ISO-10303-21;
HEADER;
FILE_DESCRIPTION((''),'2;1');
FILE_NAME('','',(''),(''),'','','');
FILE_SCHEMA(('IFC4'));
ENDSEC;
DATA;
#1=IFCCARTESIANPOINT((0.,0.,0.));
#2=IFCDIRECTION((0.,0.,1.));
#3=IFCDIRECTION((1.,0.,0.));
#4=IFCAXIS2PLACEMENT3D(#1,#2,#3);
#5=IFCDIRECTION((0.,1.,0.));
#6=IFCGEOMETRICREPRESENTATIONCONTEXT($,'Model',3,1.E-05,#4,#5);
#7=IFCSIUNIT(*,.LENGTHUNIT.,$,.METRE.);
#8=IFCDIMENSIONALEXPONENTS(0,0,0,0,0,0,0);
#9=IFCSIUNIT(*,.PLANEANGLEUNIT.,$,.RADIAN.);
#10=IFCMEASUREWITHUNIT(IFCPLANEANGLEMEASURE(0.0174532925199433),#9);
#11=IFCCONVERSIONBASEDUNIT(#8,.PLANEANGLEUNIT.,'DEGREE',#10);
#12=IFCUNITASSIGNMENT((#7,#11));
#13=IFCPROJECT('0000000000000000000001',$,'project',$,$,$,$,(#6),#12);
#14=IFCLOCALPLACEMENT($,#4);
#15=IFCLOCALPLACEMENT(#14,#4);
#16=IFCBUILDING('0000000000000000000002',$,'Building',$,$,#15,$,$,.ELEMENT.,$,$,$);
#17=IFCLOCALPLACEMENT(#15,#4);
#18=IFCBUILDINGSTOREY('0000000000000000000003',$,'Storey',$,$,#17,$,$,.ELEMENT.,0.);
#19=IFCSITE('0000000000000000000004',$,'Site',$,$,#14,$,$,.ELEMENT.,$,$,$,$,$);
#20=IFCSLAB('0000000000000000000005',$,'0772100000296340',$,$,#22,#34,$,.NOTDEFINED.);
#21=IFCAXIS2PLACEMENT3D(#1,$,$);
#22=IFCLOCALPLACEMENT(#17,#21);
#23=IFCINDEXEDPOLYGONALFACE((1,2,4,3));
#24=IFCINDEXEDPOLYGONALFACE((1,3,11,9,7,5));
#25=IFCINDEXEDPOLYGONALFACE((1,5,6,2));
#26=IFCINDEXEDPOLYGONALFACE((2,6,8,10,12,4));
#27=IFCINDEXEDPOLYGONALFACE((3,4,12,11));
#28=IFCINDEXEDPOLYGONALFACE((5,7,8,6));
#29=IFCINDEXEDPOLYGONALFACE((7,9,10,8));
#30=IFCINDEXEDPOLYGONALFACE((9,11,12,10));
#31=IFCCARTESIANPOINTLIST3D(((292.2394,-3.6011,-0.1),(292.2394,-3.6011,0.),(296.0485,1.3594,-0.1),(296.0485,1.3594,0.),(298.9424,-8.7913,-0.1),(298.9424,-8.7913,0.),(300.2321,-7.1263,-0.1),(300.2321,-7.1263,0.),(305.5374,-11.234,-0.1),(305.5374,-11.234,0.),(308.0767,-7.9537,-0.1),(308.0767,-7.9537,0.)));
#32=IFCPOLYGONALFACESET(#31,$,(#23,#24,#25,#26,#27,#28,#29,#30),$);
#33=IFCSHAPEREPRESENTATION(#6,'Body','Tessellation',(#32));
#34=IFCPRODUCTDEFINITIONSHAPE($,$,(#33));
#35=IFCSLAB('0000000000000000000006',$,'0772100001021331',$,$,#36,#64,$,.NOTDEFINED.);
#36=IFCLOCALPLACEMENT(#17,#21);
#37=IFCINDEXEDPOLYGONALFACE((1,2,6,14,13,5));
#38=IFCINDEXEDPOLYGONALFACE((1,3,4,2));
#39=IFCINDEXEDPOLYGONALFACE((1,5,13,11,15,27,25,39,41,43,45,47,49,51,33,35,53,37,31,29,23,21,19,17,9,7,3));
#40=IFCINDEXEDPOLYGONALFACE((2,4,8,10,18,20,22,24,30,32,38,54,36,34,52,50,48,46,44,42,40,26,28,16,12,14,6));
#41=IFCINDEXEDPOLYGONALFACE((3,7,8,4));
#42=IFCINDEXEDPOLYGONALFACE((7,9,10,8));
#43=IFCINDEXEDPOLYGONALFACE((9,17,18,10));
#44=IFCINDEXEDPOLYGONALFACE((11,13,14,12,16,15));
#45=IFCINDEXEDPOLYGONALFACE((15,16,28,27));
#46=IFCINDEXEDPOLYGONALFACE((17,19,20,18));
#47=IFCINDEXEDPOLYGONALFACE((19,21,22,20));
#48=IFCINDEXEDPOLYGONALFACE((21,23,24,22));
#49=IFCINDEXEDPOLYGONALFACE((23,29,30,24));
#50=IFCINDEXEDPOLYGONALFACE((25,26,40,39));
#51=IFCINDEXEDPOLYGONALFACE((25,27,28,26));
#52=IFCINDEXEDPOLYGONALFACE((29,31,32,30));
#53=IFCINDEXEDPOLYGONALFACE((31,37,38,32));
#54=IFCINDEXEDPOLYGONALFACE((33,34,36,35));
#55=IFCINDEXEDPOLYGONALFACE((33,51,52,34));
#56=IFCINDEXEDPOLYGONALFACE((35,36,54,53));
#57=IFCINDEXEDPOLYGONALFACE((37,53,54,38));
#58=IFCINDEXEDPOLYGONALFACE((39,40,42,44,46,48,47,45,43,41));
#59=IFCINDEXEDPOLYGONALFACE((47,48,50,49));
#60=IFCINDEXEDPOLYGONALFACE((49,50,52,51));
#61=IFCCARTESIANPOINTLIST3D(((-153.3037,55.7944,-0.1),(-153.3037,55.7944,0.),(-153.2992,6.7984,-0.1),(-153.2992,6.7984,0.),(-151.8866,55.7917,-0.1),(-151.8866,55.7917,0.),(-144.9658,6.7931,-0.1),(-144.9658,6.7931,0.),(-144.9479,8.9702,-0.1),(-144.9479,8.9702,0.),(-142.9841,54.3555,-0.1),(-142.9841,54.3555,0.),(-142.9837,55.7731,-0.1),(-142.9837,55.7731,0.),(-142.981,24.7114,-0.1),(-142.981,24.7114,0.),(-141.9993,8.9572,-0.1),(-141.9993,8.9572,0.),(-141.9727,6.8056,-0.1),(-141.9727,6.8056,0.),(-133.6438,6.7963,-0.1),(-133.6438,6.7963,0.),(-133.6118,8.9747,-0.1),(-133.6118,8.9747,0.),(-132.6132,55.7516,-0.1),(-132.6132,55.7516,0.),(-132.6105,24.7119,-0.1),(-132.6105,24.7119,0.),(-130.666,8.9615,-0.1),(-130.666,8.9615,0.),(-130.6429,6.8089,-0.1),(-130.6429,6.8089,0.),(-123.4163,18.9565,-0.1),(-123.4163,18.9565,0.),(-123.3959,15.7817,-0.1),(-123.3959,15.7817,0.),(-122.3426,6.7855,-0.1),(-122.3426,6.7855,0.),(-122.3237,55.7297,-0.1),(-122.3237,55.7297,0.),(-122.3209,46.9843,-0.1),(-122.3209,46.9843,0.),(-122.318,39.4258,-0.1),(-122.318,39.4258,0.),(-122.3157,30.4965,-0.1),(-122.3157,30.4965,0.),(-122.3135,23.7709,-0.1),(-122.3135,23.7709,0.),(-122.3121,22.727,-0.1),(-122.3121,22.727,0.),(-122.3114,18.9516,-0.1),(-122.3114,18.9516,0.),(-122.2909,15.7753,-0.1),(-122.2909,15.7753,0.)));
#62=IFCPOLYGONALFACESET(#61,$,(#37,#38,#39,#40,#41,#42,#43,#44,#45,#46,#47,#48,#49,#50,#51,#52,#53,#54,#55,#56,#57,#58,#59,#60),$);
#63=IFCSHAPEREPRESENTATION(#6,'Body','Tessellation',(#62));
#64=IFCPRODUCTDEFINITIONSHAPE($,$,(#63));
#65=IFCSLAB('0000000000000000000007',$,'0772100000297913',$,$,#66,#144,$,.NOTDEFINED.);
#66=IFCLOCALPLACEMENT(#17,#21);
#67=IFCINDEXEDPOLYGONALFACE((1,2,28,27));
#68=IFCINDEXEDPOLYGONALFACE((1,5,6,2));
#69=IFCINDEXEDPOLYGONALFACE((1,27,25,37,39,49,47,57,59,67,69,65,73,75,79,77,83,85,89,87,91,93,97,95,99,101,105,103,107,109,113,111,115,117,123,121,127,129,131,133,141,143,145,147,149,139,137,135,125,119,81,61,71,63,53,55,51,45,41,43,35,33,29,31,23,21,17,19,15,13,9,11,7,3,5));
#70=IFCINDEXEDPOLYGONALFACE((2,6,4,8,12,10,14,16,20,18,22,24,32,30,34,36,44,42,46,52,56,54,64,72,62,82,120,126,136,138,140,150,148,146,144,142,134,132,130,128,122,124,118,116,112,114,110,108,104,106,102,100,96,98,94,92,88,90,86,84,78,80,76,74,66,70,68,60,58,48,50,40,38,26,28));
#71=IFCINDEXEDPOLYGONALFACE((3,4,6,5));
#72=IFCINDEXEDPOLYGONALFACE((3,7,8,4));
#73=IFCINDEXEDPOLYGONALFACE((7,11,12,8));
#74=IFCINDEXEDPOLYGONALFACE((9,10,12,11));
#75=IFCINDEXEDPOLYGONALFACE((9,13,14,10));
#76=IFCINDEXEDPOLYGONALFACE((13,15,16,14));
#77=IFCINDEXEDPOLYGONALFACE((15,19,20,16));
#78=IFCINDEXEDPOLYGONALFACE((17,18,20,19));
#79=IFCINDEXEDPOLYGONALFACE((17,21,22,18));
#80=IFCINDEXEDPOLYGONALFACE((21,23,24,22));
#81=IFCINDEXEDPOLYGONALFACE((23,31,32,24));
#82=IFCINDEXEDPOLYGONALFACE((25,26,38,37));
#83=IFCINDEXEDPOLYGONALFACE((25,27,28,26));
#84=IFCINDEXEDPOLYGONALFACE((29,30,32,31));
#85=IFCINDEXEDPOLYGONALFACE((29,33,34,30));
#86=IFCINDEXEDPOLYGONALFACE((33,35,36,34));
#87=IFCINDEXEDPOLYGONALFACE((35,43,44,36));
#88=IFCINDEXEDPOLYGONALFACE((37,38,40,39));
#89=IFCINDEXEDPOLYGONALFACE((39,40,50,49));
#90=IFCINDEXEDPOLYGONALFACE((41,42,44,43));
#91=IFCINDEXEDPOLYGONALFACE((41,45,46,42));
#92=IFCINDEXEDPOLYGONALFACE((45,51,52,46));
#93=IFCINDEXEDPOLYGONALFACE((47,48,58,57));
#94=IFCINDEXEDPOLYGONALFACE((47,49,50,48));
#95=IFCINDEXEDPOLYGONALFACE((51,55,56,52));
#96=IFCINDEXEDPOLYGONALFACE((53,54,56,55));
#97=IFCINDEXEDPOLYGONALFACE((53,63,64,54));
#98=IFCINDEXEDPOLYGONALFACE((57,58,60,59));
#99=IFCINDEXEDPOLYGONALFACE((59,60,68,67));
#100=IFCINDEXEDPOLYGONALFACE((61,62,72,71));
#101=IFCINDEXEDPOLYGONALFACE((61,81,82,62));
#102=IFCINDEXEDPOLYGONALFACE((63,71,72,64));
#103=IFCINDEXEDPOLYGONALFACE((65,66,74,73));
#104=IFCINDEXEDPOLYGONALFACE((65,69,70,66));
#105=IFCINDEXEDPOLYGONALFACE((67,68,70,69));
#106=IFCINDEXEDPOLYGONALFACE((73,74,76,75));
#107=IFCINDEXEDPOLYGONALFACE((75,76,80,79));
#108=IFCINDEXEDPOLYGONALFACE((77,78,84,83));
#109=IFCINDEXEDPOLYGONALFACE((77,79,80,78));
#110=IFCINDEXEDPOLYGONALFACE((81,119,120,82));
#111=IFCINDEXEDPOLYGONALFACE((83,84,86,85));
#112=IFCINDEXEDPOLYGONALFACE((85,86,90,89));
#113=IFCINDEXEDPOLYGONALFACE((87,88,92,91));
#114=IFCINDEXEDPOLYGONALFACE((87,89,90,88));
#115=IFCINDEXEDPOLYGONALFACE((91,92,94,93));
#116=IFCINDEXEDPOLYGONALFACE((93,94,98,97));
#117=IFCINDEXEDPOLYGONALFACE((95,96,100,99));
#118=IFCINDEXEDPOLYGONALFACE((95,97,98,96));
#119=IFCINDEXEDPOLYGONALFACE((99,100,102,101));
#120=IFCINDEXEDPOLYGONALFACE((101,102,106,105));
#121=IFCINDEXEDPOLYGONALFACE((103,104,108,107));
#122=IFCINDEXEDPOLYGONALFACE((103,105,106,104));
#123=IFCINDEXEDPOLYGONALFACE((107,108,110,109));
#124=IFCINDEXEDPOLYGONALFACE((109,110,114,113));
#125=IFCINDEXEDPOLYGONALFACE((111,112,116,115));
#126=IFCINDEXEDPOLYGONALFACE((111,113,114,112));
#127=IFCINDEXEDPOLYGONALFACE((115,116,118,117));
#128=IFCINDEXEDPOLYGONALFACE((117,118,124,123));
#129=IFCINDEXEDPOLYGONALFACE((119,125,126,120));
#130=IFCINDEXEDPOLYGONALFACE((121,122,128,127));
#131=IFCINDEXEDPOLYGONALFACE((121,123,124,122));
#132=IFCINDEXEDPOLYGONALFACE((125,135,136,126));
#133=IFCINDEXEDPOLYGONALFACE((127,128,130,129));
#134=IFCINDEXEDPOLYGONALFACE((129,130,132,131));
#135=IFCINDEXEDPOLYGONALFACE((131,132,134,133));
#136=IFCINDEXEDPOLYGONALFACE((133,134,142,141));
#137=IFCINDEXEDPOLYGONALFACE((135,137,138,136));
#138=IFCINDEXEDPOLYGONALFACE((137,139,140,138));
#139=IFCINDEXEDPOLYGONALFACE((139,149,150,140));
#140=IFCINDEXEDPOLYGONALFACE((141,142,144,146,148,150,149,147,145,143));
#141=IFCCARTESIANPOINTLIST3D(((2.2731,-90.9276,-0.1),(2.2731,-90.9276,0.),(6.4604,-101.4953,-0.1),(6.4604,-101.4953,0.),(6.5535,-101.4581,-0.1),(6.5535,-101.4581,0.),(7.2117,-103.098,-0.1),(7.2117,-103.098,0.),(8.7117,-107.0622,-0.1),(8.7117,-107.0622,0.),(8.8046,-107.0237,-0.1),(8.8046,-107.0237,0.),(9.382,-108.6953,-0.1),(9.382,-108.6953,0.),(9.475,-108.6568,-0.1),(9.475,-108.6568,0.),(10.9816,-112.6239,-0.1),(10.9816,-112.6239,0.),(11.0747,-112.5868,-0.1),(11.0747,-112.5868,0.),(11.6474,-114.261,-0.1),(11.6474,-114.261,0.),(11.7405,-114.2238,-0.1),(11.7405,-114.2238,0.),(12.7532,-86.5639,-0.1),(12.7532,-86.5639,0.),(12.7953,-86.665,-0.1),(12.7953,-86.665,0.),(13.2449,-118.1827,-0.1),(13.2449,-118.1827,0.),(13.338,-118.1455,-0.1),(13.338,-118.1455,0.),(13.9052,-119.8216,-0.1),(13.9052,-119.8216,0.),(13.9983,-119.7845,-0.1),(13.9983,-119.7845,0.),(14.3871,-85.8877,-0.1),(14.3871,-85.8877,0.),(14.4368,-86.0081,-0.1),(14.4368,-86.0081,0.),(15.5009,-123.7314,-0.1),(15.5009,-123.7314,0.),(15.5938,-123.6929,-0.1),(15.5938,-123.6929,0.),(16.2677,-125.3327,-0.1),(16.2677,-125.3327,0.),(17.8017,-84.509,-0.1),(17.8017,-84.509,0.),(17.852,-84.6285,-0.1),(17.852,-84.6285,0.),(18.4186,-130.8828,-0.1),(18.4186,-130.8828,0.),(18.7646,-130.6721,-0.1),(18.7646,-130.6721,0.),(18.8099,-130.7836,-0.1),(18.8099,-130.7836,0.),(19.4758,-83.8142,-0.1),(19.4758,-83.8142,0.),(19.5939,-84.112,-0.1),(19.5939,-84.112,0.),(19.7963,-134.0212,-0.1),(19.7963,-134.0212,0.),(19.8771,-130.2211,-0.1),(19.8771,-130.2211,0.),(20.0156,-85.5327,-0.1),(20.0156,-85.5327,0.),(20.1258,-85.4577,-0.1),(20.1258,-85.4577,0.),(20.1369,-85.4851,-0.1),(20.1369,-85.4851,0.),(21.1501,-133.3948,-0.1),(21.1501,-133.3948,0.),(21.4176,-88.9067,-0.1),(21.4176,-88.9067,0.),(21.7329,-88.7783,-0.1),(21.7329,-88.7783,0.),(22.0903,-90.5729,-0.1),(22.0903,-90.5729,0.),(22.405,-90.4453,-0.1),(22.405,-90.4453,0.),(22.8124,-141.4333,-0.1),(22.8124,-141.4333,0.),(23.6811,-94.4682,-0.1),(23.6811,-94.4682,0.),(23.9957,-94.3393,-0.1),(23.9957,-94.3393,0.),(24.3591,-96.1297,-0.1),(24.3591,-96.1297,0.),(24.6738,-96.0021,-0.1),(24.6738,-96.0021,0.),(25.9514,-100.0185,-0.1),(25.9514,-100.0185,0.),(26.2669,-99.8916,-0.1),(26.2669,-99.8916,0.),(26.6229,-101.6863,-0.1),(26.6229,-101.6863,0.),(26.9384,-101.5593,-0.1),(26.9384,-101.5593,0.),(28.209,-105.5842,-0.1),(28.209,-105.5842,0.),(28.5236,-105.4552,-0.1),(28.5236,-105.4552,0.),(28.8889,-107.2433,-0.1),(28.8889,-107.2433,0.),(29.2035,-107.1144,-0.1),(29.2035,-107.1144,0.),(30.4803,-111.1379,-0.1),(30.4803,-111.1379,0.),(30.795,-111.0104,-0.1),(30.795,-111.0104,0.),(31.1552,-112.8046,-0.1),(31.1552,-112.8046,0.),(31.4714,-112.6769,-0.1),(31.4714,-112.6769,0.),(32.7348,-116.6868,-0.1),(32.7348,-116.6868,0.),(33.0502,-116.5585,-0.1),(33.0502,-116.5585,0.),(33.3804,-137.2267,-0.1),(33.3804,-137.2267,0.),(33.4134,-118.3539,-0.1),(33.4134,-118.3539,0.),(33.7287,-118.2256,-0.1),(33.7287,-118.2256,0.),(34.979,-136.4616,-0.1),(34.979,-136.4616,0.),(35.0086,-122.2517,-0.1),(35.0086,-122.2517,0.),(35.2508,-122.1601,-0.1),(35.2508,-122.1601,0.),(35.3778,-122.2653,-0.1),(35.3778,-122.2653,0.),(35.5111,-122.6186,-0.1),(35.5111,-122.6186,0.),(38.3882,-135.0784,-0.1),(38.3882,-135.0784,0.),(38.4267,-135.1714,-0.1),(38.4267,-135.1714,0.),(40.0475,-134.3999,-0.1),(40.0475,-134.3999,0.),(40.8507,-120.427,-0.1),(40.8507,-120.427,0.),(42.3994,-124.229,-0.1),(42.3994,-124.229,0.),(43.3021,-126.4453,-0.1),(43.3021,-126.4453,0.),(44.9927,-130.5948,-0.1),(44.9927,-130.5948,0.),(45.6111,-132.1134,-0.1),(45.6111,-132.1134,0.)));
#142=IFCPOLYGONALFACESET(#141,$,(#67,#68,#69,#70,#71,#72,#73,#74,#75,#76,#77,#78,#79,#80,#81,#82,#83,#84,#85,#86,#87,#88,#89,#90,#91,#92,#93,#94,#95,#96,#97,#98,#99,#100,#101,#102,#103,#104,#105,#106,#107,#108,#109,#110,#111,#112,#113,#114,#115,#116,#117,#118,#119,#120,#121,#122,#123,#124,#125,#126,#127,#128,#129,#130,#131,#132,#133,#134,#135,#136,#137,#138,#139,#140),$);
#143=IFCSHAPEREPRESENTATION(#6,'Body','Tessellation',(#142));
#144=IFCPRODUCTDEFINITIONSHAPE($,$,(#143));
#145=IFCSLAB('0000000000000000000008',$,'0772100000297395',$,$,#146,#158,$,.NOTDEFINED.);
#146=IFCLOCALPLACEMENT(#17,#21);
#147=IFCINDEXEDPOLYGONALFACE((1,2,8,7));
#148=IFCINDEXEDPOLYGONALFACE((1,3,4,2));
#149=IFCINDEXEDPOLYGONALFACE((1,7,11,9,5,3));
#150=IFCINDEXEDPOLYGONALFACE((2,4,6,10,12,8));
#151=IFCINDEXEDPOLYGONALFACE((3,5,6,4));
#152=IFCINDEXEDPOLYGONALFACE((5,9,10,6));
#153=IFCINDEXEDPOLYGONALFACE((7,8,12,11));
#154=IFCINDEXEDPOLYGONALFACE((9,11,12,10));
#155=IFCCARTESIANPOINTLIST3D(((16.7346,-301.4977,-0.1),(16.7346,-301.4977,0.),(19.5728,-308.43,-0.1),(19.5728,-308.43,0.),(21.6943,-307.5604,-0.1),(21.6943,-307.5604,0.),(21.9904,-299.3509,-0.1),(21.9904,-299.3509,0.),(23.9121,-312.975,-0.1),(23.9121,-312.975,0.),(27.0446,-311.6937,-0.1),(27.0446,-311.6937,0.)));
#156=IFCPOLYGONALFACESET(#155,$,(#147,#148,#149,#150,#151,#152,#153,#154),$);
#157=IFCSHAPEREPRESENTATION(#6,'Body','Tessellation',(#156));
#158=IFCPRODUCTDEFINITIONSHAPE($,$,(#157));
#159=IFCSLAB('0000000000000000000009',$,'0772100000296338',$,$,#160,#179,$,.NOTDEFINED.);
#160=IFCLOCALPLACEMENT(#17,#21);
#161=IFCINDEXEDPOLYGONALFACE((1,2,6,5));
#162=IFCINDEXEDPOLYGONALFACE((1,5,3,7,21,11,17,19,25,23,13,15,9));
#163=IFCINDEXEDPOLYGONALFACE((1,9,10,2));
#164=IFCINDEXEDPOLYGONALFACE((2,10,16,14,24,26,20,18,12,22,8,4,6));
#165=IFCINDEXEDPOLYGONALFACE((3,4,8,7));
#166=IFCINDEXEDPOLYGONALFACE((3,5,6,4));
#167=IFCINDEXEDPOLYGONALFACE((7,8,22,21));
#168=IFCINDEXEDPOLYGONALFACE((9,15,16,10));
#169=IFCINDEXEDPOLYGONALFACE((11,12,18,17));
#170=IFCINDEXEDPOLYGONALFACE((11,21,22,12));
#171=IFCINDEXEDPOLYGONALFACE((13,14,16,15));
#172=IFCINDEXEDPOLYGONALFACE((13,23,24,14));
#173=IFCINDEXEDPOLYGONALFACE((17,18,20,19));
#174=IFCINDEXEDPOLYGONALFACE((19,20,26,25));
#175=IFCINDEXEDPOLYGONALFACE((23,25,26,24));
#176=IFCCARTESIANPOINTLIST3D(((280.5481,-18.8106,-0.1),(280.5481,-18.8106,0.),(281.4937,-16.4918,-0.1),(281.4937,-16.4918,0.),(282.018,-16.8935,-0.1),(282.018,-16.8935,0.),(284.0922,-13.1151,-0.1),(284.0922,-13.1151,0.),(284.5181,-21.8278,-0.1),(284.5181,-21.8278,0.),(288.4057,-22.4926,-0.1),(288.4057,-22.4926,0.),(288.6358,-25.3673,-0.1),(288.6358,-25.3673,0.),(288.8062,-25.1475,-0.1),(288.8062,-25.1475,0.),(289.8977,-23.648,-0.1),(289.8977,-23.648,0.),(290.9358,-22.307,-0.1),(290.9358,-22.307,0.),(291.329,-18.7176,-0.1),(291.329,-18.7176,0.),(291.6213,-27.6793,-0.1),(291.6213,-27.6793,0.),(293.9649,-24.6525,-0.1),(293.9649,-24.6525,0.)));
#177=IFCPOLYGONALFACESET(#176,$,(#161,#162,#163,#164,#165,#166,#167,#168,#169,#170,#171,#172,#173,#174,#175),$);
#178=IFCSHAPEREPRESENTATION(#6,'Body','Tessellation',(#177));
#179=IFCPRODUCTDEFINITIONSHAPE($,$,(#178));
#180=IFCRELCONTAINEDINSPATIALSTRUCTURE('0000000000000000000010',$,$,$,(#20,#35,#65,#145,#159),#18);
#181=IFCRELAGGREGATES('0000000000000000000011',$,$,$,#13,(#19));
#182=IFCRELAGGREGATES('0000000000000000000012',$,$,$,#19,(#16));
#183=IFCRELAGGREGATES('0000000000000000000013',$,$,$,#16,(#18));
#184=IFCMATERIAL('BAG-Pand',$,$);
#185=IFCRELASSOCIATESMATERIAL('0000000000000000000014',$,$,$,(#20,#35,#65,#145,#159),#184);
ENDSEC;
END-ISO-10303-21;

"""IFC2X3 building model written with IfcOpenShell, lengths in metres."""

from ifc_helpers import new_model, entity, si_unit, converted_unit, direction, frame, origin_with_axes, place, context, project, spatial, polyline, outline, extrude, material, element, save


model = new_model("IFC2X3")

# Units and contexts
model_context = context("Model", 3, precision=1e-05, world=origin_with_axes(), true_north=direction((0.0, 1.0, 0.0)))
ifc_project = project(units=[si_unit("LENGTHUNIT", "METRE"), converted_unit("PLANEANGLEUNIT", "DEGREE", entity("IfcPlaneAngleMeasure", 0.0174532925199433), si_unit("PLANEANGLEUNIT", "RADIAN"), dimensions=[0, 0, 0, 0, 0, 0, 0])], contexts=[model_context])

# Site, building, storey
site_placement = place(None, origin_with_axes())
site = spatial("IfcSite", under=ifc_project, at=site_placement, Name="Site", CompositionType="ELEMENT")
building_placement = place(site_placement, origin_with_axes())
building = spatial("IfcBuilding", under=site, at=building_placement, Name="Building", CompositionType="ELEMENT")
storey_placement = place(building_placement, origin_with_axes())
storey = spatial("IfcBuildingStorey", under=building, at=storey_placement, Name="Storey", CompositionType="ELEMENT", Elevation=0.0)

# Slabs
ifc_material = material(Name="BAG-Pand")
slab_1_placement = place(storey_placement, frame((0.0, 0.0, -0.1), z_axis=(0.0, 0.0, 1.0), x_axis=(1.0, 0.0, 0.0)))
element("IfcSlab", 1, at=slab_1_placement, inside=storey, material=ifc_material, Name="0772100000296340", PredefinedType="NOTDEFINED", context=model_context, shape_type="SweptSolid", body=[
    extrude(outline(polyline([(296.0485, 1.3594), (308.0767, -7.9537), (305.5374, -11.234), (300.2321, -7.1263), (298.9424, -8.7913), (292.2394, -3.6011), (296.0485, 1.3594)])), origin_with_axes(), (0.0, 0.0, 1.0), 0.1),
])
slab_2_placement = place(storey_placement, frame((0.0, 0.0, -0.1), z_axis=(0.0, 0.0, 1.0), x_axis=(1.0, 0.0, 0.0)))
element("IfcSlab", 2, at=slab_2_placement, inside=storey, material=ifc_material, Name="0772100001021331", PredefinedType="NOTDEFINED", context=model_context, shape_type="SweptSolid", body=[
    extrude(outline(polyline([(-153.3037, 55.7944), (-151.8866, 55.7917), (-142.9837, 55.7731), (-142.9841, 54.3555), (-142.981, 24.7114), (-132.6105, 24.7119), (-132.6132, 55.7516), (-122.3237, 55.7297), (-122.3209, 46.9843), (-122.318, 39.4258), (-122.3157, 30.4965), (-122.3135, 23.7709), (-122.3121, 22.727), (-122.3114, 18.9516), (-123.4163, 18.9565), (-123.3959, 15.7817), (-122.2909, 15.7753), (-122.3426, 6.7855), (-130.6429, 6.8089), (-130.666, 8.9615), (-133.6118, 8.9747), (-133.6438, 6.7963), (-141.9727, 6.8056), (-141.9993, 8.9572), (-144.9479, 8.9702), (-144.9658, 6.7931), (-153.2992, 6.7984), (-153.3037, 55.7944)])), origin_with_axes(), (0.0, 0.0, 1.0), 0.1),
])
slab_3_placement = place(storey_placement, frame((0.0, 0.0, -0.1), z_axis=(0.0, 0.0, 1.0), x_axis=(1.0, 0.0, 0.0)))
element("IfcSlab", 3, at=slab_3_placement, inside=storey, material=ifc_material, Name="0772100000297913", PredefinedType="NOTDEFINED", context=model_context, shape_type="SweptSolid", body=[
    extrude(outline(polyline([(19.7963, -134.0212), (21.1501, -133.3948), (19.8771, -130.2211), (18.7646, -130.6721), (18.8099, -130.7836), (18.4186, -130.8828), (16.2677, -125.3327), (15.5009, -123.7314), (15.5938, -123.6929), (13.9983, -119.7845), (13.9052, -119.8216), (13.2449, -118.1827), (13.338, -118.1455), (11.7405, -114.2238), (11.6474, -114.261), (10.9816, -112.6239), (11.0747, -112.5868), (9.475, -108.6568), (9.382, -108.6953), (8.7117, -107.0622), (8.8046, -107.0237), (7.2117, -103.098), (6.4604, -101.4953), (6.5535, -101.4581), (2.2731, -90.9276), (12.7953, -86.665), (12.7532, -86.5639), (14.3871, -85.8877), (14.4368, -86.0081), (17.852, -84.6285), (17.8017, -84.509), (19.4758, -83.8142), (19.5939, -84.112), (20.1258, -85.4577), (20.1369, -85.4851), (20.0156, -85.5327), (21.4176, -88.9067), (21.7329, -88.7783), (22.405, -90.4453), (22.0903, -90.5729), (23.6811, -94.4682), (23.9957, -94.3393), (24.6738, -96.0021), (24.3591, -96.1297), (25.9514, -100.0185), (26.2669, -99.8916), (26.9384, -101.5593), (26.6229, -101.6863), (28.209, -105.5842), (28.5236, -105.4552), (29.2035, -107.1144), (28.8889, -107.2433), (30.4803, -111.1379), (30.795, -111.0104), (31.4714, -112.6769), (31.1552, -112.8046), (32.7348, -116.6868), (33.0502, -116.5585), (33.7287, -118.2256), (33.4134, -118.3539), (35.0086, -122.2517), (35.2508, -122.1601), (35.3778, -122.2653), (35.5111, -122.6186), (40.8507, -120.427), (42.3994, -124.229), (43.3021, -126.4453), (44.9927, -130.5948), (45.6111, -132.1134), (40.0475, -134.3999), (38.4267, -135.1714), (38.3882, -135.0784), (34.979, -136.4616), (33.3804, -137.2267), (22.8124, -141.4333), (19.7963, -134.0212)])), origin_with_axes(), (0.0, 0.0, 1.0), 0.1),
])
slab_4_placement = place(storey_placement, frame((0.0, 0.0, -0.1), z_axis=(0.0, 0.0, 1.0), x_axis=(1.0, 0.0, 0.0)))
element("IfcSlab", 4, at=slab_4_placement, inside=storey, material=ifc_material, Name="0772100000297395", PredefinedType="NOTDEFINED", context=model_context, shape_type="SweptSolid", body=[
    extrude(outline(polyline([(21.6943, -307.5604), (19.5728, -308.43), (16.7346, -301.4977), (21.9904, -299.3509), (27.0446, -311.6937), (23.9121, -312.975), (21.6943, -307.5604)])), origin_with_axes(), (0.0, 0.0, 1.0), 0.1),
])
slab_5_placement = place(storey_placement, frame((0.0, 0.0, -0.1), z_axis=(0.0, 0.0, 1.0), x_axis=(1.0, 0.0, 0.0)))
element("IfcSlab", 5, at=slab_5_placement, inside=storey, material=ifc_material, Name="0772100000296338", PredefinedType="NOTDEFINED", context=model_context, shape_type="SweptSolid", body=[
    extrude(outline(polyline([(282.018, -16.8935), (281.4937, -16.4918), (284.0922, -13.1151), (291.329, -18.7176), (288.4057, -22.4926), (289.8977, -23.648), (290.9358, -22.307), (293.9649, -24.6525), (291.6213, -27.6793), (288.6358, -25.3673), (288.8062, -25.1475), (284.5181, -21.8278), (280.5481, -18.8106), (282.018, -16.8935)])), origin_with_axes(), (0.0, 0.0, 1.0), 0.1),
])

save(model, "model.ifc")
